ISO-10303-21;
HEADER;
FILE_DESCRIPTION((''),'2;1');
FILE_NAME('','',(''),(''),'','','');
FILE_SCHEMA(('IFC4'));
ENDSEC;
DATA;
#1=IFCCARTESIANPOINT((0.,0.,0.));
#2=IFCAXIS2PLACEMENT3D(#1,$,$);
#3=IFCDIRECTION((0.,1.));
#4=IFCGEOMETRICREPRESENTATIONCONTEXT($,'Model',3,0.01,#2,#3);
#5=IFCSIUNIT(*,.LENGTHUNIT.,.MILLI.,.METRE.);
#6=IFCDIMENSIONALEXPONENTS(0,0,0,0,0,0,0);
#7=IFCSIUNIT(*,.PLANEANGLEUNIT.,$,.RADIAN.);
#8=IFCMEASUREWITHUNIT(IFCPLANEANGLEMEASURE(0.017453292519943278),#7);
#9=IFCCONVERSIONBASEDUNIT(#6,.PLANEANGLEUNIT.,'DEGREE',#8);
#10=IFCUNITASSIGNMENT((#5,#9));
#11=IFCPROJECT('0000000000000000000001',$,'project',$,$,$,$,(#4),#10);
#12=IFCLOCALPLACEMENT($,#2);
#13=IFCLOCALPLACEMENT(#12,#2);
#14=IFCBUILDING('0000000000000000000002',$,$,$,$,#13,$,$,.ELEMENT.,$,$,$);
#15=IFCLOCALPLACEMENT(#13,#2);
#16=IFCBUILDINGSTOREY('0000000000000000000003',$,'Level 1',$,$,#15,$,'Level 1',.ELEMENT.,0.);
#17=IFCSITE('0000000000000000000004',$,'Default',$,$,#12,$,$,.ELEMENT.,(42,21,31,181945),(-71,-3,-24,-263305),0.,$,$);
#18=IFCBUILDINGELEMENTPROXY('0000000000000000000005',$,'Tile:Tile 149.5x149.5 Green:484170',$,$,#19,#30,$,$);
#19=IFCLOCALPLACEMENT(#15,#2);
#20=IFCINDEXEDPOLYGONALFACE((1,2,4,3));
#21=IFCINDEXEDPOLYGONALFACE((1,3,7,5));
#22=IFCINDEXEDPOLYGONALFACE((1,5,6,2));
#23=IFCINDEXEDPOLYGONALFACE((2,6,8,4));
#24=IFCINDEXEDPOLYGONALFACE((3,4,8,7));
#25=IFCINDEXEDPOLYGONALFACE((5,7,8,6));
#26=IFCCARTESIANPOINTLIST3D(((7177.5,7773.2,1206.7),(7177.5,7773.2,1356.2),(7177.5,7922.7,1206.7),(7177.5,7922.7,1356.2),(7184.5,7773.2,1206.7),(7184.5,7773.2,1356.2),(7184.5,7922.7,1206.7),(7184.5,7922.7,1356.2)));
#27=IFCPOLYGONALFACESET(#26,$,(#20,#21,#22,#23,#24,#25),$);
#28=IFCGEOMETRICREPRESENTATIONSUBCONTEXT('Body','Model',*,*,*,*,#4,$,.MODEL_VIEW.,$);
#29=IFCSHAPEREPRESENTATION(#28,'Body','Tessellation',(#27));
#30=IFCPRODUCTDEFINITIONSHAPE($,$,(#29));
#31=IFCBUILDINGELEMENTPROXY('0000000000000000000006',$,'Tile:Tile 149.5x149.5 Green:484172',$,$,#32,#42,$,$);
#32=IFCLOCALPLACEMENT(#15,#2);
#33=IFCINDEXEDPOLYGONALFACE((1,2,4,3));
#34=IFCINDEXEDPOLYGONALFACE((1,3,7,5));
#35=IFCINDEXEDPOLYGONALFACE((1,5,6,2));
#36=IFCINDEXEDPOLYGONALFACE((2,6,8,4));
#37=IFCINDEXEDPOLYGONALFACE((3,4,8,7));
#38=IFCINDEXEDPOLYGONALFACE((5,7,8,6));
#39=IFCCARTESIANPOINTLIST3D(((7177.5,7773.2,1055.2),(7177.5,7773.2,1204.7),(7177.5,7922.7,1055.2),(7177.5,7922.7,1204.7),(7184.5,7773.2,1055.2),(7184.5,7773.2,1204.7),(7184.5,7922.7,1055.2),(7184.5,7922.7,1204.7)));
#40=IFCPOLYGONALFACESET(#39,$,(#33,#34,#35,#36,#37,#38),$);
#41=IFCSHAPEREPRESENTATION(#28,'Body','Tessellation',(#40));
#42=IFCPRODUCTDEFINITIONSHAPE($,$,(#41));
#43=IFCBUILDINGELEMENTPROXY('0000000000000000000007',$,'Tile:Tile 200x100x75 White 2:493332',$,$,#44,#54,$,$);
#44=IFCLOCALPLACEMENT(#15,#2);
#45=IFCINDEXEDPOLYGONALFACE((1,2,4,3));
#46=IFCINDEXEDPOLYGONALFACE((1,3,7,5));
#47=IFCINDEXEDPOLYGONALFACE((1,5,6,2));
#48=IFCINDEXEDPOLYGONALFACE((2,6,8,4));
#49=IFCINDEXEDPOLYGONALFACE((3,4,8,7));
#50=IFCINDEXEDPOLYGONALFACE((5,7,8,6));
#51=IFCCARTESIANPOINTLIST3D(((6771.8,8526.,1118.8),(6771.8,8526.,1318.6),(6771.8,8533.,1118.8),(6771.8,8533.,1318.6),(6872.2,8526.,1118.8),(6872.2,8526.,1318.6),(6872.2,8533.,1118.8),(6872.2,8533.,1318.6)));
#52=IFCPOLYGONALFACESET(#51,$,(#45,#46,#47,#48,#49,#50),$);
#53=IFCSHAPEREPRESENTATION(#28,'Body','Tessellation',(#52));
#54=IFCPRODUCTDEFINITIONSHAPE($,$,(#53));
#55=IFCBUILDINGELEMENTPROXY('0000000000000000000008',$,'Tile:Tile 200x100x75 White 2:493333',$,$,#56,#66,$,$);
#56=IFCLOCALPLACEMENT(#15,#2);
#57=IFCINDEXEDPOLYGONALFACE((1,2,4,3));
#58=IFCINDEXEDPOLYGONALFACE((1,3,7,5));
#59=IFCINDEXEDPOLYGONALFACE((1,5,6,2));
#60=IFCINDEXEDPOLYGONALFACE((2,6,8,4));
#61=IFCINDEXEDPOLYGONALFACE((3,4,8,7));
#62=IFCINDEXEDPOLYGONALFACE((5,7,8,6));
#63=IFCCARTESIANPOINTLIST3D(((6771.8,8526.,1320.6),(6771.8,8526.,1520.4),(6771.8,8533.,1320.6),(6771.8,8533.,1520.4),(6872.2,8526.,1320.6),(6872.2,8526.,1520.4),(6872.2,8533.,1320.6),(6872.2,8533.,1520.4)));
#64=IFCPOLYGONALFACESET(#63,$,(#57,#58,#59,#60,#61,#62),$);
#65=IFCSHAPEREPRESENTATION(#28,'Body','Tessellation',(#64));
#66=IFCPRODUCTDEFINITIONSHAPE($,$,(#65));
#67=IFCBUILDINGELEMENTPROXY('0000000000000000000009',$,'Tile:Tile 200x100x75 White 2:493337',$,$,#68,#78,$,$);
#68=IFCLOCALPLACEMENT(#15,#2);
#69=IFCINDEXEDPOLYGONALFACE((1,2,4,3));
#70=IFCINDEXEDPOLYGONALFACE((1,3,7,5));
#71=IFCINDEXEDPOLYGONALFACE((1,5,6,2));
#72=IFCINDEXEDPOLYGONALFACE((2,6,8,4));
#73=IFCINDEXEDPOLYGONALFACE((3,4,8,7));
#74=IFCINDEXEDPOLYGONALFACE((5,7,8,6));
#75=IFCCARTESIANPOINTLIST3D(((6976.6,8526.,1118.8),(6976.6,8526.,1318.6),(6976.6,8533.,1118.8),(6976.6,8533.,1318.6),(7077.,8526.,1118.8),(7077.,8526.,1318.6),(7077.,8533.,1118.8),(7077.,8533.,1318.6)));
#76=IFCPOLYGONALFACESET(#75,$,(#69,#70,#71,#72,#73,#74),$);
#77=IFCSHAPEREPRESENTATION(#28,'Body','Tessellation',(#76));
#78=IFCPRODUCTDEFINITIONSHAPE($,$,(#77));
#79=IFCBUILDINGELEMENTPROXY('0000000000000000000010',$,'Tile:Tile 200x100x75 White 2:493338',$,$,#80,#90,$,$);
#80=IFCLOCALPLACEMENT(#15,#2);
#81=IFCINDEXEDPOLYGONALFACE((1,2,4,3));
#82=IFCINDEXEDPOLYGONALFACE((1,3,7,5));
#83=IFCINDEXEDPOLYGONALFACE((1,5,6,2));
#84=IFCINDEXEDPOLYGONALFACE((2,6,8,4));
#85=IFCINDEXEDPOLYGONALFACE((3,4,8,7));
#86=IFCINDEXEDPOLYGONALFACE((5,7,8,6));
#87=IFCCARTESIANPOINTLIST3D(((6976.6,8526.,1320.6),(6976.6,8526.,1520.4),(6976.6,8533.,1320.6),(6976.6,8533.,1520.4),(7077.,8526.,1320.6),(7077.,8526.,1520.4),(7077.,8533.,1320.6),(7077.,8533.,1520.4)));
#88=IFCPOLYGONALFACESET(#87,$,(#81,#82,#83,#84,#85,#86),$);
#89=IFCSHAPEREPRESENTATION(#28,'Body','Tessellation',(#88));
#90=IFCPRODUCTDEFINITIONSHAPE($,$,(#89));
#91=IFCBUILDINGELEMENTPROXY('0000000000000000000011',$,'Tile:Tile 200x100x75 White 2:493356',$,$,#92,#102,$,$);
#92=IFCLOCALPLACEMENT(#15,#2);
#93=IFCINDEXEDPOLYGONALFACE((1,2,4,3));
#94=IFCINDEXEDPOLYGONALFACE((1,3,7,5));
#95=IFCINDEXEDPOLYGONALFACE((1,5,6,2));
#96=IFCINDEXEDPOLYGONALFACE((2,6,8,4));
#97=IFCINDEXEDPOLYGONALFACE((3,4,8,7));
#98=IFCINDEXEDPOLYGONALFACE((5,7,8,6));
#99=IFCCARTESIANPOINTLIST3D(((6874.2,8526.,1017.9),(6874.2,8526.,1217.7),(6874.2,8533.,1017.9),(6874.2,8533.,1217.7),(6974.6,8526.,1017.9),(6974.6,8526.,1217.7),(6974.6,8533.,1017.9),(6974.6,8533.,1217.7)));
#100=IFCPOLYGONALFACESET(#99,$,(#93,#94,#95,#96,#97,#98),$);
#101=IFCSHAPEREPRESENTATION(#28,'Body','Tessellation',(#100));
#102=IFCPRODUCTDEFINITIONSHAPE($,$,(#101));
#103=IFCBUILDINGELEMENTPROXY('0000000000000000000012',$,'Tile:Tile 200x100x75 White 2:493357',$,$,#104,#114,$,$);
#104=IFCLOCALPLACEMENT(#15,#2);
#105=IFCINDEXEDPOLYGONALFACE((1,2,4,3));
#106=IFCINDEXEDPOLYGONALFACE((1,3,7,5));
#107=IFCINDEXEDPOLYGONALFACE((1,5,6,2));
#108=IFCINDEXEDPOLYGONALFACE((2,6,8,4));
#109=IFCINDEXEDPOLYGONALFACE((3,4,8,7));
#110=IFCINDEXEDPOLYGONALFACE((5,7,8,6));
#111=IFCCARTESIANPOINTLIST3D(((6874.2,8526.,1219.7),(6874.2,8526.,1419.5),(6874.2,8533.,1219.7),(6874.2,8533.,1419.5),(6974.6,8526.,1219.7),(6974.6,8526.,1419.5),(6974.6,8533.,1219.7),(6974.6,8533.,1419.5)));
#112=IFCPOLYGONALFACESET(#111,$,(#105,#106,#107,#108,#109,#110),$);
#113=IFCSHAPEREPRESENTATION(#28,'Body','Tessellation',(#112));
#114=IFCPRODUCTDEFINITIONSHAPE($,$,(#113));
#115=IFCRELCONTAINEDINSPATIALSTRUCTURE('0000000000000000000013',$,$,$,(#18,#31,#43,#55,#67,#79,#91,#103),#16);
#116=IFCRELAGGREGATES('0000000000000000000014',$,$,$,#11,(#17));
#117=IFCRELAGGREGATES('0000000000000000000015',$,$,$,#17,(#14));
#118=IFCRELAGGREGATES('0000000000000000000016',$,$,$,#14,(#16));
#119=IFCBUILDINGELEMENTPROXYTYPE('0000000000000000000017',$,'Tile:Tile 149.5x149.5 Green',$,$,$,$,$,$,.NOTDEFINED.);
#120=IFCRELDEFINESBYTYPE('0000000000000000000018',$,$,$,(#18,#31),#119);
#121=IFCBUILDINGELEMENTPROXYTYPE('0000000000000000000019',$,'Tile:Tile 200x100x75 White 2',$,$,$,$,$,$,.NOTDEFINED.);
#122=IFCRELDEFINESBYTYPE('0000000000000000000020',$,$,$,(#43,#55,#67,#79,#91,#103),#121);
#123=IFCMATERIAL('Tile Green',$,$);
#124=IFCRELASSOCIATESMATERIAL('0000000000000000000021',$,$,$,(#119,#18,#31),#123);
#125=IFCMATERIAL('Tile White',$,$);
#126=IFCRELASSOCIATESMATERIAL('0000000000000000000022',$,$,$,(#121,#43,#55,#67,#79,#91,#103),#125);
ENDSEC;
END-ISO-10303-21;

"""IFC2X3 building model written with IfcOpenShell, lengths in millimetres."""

from ifc_helpers import new_model, entity, si_unit, converted_unit, direction, frame, frame_2d, origin, origin_2d_with_axis, place, context, subcontext, project, spatial, rectangle, extrude, source, transform, mapped, material, type_object, type_shapes, element, save


model = new_model("IFC2X3")

# Units and contexts
model_context = context("Model", 3, precision=0.01, world=origin(), true_north=direction((0.0, 1.0)))
body_context = subcontext(model_context, "Body", "Model", "MODEL_VIEW")
ifc_project = project(units=[si_unit("LENGTHUNIT", "METRE", prefix="MILLI"), converted_unit("PLANEANGLEUNIT", "DEGREE", entity("IfcPlaneAngleMeasure", 0.017453292519943278), si_unit("PLANEANGLEUNIT", "RADIAN"), dimensions=[0, 0, 0, 0, 0, 0, 0])], contexts=[model_context])

# Site, building, storey
site_placement = place(None, origin())
site = spatial("IfcSite", under=ifc_project, at=site_placement, Name="Default", CompositionType="ELEMENT", RefLatitude=(42, 21, 31, 181945), RefLongitude=(-71, -3, -24, -263305), RefElevation=0.0)
building_placement = place(site_placement, origin())
building = spatial("IfcBuilding", under=site, at=building_placement, CompositionType="ELEMENT")
storey_placement = place(building_placement, origin())
storey = spatial("IfcBuildingStorey", under=building, at=storey_placement, Name="Level 1", LongName="Level 1", CompositionType="ELEMENT", Elevation=0.0)

# Building element proxies
ifc_material_1 = material(Name="Tile White")
ifc_material_2 = material(Name="Tile Green")
building_element_proxy_type_1 = type_object("IfcBuildingElementProxyType", Name="Tile:Tile 149.5x149.5 Green", PredefinedType="NOTDEFINED", material=ifc_material_2)
shared_shape_1 = source(origin(), body_context, "Body", "SweptSolid", [
    extrude(rectangle(XDim=149.5, YDim=149.5, at=origin_2d_with_axis()), frame((-74.7, -74.8, 0.0), z_axis=(0.0, 0.0, 1.0), x_axis=(0.0, -1.0, 0.0)), (0.0, 0.0, 1.0), 7.0),
])
type_shapes(building_element_proxy_type_1, [shared_shape_1])
for number, where, z_axis, x_axis, name in (
    (1, (7184.5, 7922.7, 1356.2), (-1.0, 0.0, 0.0), (0.0, 0.0, 1.0), "Tile:Tile 149.5x149.5 Green:484170"),
    (2, (7184.5, 7922.7, 1204.7), (-1.0, 0.0, 0.0), (0.0, 0.0, 1.0), "Tile:Tile 149.5x149.5 Green:484172"),
):
    element("IfcBuildingElementProxy", number, at=place(storey_placement, frame(where, z_axis=z_axis, x_axis=x_axis)), inside=storey, type_object=building_element_proxy_type_1, material=ifc_material_2, Name=name, context=body_context, shape_type="MappedRepresentation", body=[
        mapped(shared_shape_1, transform((0.0, 0.0, 0.0), scale=1.0)),
    ])
building_element_proxy_type_2 = type_object("IfcBuildingElementProxyType", Name="Tile:Tile 200x100x75 White 2", PredefinedType="NOTDEFINED", material=ifc_material_1)
shared_shape_2 = source(origin(), body_context, "Body", "SweptSolid", [
    extrude(rectangle(XDim=199.8, YDim=100.4, at=frame_2d((0.0, 0.0), x_axis=(1.0, 0.0))), frame((-50.2, -99.9, 0.0), z_axis=(0.0, 0.0, 1.0), x_axis=(0.0, -1.0, 0.0)), (0.0, 0.0, 1.0), 7.0),
])
type_shapes(building_element_proxy_type_2, [shared_shape_2])
for number, where, z_axis, x_axis, name in (
    (3, (6872.2, 8533.0, 1318.6), (0.0, -1.0, 0.0), (1.0, 0.0, 0.0), "Tile:Tile 200x100x75 White 2:493332"),
    (4, (6872.2, 8533.0, 1520.4), (0.0, -1.0, 0.0), (1.0, 0.0, 0.0), "Tile:Tile 200x100x75 White 2:493333"),
    (5, (7077.0, 8533.0, 1318.6), (0.0, -1.0, 0.0), (1.0, 0.0, 0.0), "Tile:Tile 200x100x75 White 2:493337"),
    (6, (7077.0, 8533.0, 1520.4), (0.0, -1.0, 0.0), (1.0, 0.0, 0.0), "Tile:Tile 200x100x75 White 2:493338"),
    (7, (6974.6, 8533.0, 1217.7), (0.0, -1.0, 0.0), (1.0, 0.0, 0.0), "Tile:Tile 200x100x75 White 2:493356"),
    (8, (6974.6, 8533.0, 1419.5), (0.0, -1.0, 0.0), (1.0, 0.0, 0.0), "Tile:Tile 200x100x75 White 2:493357"),
):
    element("IfcBuildingElementProxy", number, at=place(storey_placement, frame(where, z_axis=z_axis, x_axis=x_axis)), inside=storey, type_object=building_element_proxy_type_2, material=ifc_material_1, Name=name, context=body_context, shape_type="MappedRepresentation", body=[
        mapped(shared_shape_2, transform((0.0, 0.0, 0.0), scale=1.0)),
    ])

save(model, "model.ifc")
